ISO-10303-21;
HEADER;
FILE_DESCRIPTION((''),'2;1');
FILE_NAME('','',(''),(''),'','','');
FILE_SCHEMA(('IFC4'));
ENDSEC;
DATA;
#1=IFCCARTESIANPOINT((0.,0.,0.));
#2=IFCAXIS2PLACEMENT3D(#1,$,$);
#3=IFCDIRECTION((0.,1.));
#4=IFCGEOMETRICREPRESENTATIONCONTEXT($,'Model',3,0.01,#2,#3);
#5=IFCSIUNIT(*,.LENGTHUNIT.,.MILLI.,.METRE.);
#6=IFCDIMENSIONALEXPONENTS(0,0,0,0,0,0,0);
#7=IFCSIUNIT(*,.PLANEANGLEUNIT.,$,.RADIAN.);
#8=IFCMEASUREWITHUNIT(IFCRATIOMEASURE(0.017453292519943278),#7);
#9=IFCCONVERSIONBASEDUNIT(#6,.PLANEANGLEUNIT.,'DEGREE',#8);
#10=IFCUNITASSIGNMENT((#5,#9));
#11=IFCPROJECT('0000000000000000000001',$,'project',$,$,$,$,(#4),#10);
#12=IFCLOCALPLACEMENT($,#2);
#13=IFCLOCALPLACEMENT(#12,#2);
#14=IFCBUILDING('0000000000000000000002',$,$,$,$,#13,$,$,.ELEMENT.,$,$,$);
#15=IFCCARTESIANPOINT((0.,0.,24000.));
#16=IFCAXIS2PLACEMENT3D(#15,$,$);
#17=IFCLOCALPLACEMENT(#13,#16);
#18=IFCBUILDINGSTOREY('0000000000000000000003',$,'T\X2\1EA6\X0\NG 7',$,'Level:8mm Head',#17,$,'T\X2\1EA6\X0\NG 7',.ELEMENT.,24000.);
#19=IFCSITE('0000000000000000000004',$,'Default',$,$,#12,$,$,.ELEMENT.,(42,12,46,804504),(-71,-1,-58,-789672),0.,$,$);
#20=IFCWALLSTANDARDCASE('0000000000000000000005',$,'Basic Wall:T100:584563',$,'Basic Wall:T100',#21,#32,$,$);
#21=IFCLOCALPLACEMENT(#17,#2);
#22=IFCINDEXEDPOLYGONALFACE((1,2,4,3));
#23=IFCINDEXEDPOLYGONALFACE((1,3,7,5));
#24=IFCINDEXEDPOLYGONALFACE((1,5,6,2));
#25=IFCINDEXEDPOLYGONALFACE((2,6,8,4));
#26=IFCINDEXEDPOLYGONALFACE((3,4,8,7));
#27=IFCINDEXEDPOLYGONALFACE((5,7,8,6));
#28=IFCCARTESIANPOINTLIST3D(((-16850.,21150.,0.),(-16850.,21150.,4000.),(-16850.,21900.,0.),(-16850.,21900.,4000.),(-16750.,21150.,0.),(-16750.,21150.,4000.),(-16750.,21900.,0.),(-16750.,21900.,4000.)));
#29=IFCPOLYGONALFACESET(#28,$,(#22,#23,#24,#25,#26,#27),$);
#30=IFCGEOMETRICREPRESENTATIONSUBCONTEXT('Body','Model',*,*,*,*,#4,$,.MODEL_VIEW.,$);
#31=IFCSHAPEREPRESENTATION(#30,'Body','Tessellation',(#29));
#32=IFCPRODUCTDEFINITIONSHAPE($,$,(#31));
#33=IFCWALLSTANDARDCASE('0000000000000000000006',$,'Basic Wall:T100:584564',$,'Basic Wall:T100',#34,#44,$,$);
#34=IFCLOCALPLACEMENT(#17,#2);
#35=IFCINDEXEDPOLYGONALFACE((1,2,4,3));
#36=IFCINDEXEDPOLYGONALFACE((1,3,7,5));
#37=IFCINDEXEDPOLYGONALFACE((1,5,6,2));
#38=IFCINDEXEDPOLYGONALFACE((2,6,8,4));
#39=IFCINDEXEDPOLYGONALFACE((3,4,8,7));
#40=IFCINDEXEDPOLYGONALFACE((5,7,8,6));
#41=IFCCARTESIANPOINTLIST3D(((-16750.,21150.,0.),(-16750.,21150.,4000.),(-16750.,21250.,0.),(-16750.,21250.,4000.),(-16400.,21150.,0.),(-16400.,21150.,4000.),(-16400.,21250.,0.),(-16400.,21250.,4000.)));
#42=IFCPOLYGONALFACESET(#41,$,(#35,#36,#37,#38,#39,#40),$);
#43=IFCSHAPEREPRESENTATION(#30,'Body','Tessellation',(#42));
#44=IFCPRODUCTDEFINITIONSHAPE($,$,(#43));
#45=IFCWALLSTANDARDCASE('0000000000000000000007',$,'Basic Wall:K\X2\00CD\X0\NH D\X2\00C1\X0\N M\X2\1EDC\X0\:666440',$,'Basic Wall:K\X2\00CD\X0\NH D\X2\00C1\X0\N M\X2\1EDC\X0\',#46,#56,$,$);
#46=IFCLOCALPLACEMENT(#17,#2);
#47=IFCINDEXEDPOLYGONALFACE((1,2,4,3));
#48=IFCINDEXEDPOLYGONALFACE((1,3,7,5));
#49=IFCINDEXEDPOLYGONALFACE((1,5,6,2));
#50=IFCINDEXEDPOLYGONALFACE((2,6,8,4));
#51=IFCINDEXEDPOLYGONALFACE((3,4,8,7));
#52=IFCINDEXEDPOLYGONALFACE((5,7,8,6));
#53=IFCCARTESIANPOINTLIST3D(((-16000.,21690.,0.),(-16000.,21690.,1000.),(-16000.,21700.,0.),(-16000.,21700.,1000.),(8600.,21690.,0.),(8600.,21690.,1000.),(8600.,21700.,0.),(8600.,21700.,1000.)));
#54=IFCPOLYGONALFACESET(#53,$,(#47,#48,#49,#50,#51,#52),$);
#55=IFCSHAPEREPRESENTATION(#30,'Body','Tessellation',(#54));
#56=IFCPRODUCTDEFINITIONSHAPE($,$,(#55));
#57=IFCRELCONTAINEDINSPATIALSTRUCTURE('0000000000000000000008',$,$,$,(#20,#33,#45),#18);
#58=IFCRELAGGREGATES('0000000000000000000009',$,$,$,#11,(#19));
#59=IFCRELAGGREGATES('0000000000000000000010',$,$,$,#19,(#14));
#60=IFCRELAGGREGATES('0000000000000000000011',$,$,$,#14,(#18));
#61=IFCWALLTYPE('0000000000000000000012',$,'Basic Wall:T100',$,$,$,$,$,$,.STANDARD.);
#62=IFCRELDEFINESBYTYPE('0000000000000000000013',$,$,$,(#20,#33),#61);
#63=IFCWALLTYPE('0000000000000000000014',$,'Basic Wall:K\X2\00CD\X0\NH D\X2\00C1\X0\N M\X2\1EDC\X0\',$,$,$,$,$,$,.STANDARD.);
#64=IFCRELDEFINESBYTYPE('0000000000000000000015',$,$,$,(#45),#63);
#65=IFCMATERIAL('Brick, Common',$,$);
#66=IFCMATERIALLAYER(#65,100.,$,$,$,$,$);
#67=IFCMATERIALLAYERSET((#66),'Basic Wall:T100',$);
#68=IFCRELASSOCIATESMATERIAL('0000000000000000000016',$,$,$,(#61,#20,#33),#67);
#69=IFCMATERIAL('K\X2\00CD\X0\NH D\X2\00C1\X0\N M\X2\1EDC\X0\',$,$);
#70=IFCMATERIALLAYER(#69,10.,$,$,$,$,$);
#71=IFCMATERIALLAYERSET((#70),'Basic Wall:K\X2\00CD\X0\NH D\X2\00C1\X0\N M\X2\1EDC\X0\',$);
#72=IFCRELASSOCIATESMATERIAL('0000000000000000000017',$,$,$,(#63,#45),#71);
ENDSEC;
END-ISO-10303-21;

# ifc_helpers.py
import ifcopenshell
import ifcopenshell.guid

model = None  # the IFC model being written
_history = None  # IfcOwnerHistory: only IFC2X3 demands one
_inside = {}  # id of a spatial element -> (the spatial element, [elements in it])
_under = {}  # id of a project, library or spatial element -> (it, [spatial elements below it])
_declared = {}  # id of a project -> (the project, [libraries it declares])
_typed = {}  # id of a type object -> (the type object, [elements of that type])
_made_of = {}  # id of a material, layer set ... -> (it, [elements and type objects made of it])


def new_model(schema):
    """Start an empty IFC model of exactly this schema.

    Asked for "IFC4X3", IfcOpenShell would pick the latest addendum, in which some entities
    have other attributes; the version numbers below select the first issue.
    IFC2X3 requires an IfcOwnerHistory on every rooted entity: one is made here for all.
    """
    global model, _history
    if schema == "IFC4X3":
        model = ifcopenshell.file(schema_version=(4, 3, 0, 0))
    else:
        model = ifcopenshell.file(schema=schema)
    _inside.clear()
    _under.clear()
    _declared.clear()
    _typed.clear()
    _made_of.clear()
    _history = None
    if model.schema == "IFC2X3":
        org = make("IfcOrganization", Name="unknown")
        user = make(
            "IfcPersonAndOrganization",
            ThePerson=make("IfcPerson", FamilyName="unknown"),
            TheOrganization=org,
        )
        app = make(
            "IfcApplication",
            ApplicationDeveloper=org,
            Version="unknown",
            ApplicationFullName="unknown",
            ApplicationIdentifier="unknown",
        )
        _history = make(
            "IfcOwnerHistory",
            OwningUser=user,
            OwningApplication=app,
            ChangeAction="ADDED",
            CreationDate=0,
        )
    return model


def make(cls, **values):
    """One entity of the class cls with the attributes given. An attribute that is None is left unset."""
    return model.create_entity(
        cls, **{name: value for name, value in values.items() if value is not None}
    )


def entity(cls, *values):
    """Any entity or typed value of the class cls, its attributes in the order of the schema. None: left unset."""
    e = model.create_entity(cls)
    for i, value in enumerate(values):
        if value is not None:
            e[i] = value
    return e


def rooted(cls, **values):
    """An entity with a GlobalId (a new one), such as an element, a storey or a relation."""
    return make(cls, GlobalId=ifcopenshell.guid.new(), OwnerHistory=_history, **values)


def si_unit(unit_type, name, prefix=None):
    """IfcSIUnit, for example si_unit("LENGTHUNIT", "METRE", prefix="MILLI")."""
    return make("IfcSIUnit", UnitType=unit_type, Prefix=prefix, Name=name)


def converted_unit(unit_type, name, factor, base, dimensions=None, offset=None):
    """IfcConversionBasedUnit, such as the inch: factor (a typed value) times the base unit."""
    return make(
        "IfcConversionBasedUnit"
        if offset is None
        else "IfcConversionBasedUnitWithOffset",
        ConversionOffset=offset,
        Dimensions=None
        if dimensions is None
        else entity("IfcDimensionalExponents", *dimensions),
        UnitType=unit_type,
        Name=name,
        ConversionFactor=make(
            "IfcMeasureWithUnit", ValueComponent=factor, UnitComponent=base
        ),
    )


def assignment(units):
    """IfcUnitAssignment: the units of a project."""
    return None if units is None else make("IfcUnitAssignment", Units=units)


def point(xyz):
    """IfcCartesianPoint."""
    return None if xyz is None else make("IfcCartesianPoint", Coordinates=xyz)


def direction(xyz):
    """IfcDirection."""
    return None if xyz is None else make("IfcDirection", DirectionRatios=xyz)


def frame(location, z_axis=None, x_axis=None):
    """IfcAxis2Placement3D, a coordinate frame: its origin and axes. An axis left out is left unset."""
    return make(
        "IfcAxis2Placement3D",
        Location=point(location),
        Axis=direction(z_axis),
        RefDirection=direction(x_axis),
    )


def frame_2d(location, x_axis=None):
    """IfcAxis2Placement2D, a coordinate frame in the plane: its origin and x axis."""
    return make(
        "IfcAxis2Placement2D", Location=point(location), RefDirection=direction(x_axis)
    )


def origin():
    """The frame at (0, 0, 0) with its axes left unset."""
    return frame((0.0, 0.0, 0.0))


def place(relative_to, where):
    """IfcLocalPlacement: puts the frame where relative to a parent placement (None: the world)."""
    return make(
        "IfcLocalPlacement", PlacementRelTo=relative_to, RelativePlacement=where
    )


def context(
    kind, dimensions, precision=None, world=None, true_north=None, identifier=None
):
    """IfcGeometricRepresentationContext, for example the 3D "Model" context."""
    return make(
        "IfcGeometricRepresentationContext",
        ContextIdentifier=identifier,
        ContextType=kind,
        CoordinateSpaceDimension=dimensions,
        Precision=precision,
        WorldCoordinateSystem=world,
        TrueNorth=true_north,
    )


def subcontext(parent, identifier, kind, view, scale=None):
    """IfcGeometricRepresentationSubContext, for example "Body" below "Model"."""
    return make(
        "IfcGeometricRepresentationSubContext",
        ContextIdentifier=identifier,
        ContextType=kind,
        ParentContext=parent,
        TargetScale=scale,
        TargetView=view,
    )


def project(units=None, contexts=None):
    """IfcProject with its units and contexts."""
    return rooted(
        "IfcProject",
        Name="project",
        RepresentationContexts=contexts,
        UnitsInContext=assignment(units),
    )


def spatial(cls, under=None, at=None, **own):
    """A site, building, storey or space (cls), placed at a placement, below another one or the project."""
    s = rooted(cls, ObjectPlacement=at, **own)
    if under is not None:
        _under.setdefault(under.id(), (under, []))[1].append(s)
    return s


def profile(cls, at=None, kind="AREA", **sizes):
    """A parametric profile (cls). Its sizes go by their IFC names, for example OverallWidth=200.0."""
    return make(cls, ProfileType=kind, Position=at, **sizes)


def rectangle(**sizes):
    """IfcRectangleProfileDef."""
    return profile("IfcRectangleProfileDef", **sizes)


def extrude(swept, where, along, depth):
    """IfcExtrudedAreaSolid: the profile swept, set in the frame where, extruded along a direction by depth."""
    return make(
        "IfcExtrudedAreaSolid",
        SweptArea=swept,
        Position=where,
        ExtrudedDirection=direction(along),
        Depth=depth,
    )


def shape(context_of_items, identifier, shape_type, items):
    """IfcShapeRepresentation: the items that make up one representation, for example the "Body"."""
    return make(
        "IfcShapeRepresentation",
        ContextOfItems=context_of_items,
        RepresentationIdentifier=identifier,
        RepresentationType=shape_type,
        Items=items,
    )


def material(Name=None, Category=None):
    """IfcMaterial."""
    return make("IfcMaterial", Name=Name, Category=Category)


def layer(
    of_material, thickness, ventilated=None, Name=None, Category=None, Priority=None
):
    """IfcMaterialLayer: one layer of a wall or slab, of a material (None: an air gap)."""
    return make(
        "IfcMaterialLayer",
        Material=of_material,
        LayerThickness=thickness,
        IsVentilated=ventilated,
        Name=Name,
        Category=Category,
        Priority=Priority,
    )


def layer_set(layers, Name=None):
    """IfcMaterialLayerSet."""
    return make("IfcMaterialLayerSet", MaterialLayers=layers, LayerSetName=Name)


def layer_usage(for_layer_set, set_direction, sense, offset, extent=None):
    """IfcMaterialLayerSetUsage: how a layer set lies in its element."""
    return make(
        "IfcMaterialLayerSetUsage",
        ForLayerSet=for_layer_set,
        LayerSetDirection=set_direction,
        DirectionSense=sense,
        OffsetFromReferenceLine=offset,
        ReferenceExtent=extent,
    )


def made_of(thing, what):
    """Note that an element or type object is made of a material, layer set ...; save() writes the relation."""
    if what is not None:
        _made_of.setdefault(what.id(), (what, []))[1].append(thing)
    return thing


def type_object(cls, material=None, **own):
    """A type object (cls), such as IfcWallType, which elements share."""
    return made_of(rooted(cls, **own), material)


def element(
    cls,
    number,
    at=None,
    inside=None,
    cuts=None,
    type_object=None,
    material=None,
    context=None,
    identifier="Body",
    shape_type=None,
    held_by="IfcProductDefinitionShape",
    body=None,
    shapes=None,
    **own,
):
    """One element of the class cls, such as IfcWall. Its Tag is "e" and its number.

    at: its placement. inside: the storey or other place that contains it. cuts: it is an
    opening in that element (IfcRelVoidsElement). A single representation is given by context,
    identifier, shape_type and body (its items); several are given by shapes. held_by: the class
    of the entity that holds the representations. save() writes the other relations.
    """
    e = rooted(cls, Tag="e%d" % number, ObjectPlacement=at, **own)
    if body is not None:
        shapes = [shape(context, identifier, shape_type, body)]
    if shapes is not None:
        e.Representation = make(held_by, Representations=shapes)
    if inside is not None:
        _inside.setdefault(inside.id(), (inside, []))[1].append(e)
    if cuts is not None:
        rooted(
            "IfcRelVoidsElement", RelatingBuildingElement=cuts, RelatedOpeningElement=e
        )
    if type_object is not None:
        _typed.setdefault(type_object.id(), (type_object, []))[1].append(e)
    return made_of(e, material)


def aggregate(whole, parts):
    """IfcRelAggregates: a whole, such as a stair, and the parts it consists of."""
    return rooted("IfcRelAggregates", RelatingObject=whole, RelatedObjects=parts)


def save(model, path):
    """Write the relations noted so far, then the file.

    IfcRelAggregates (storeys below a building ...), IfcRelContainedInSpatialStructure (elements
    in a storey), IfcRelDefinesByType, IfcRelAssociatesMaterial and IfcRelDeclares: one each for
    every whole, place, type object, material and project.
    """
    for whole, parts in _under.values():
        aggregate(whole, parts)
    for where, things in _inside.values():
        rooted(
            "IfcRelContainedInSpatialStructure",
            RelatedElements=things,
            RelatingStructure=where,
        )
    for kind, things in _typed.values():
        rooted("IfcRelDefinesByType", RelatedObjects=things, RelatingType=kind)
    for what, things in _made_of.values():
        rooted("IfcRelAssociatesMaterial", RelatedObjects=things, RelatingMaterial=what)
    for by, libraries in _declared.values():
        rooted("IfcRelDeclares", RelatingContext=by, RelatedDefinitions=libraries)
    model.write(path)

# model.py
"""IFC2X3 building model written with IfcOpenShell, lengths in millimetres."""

from ifc_helpers import new_model, entity, si_unit, converted_unit, direction, frame, frame_2d, origin, place, context, subcontext, project, spatial, rectangle, extrude, material, layer, layer_set, layer_usage, type_object, element, save


model = new_model("IFC2X3")

# Units and contexts
model_context = context("Model", 3, precision=0.01, world=origin(), true_north=direction((0.0, 1.0)))
body_context = subcontext(model_context, "Body", "Model", "MODEL_VIEW")
ifc_project = project(units=[si_unit("LENGTHUNIT", "METRE", prefix="MILLI"), converted_unit("PLANEANGLEUNIT", "DEGREE", entity("IfcRatioMeasure", 0.017453292519943278), si_unit("PLANEANGLEUNIT", "RADIAN"), dimensions=[0, 0, 0, 0, 0, 0, 0])], contexts=[model_context])

# Site, building, storey
site_placement = place(None, origin())
site = spatial("IfcSite", under=ifc_project, at=site_placement, Name="Default", CompositionType="ELEMENT", RefLatitude=(42, 12, 46, 804504), RefLongitude=(-71, -1, -58, -789672), RefElevation=0.0)
building_placement = place(site_placement, origin())
building = spatial("IfcBuilding", under=site, at=building_placement, CompositionType="ELEMENT")
storey_placement = place(building_placement, frame((0.0, 0.0, 24000.0)))
storey = spatial("IfcBuildingStorey", under=building, at=storey_placement, Name="TẦNG 7", ObjectType="Level:8mm Head", LongName="TẦNG 7", CompositionType="ELEMENT", Elevation=24000.0)

# Walls
ifc_material_1 = material(Name="Brick, Common")
ifc_layer_1 = layer(ifc_material_1, 100.0)
ifc_layer_set_1 = layer_set([ifc_layer_1], Name="Basic Wall:T100")
ifc_layer_usage_1 = layer_usage(ifc_layer_set_1, "AXIS2", "POSITIVE", -50.0)
wall_type_1 = type_object("IfcWallType", Name="Basic Wall:T100", PredefinedType="STANDARD", material=ifc_layer_set_1)
wall_1_placement = place(storey_placement, frame((-16800.0, 21900.0, 0.0), z_axis=(0.0, 0.0, 1.0), x_axis=(0.0, -1.0, 0.0)))
element("IfcWallStandardCase", 1, at=wall_1_placement, inside=storey, type_object=wall_type_1, material=ifc_layer_usage_1, Name="Basic Wall:T100:584563", ObjectType="Basic Wall:T100", context=body_context, shape_type="SweptSolid", body=[
    extrude(rectangle(XDim=750.0, YDim=100.0, at=frame_2d((375.0, 0.0), x_axis=(-1.0, 0.0))), origin(), (0.0, 0.0, 1.0), 4000.0),
])
wall_2_placement = place(storey_placement, frame((-16750.0, 21200.0, 0.0)))
element("IfcWallStandardCase", 2, at=wall_2_placement, inside=storey, type_object=wall_type_1, material=ifc_layer_usage_1, Name="Basic Wall:T100:584564", ObjectType="Basic Wall:T100", context=body_context, shape_type="SweptSolid", body=[
    extrude(rectangle(XDim=350.0, YDim=100.0, at=frame_2d((175.0, 0.0), x_axis=(-1.0, 0.0))), origin(), (0.0, 0.0, 1.0), 4000.0),
])

# Wall
ifc_material_2 = material(Name="KÍNH DÁN MỜ")
ifc_layer_2 = layer(ifc_material_2, 10.0)
ifc_layer_set_2 = layer_set([ifc_layer_2], Name="Basic Wall:KÍNH DÁN MỜ")
ifc_layer_usage_2 = layer_usage(ifc_layer_set_2, "AXIS2", "NEGATIVE", 5.0)
wall_type_2 = type_object("IfcWallType", Name="Basic Wall:KÍNH DÁN MỜ", PredefinedType="STANDARD", material=ifc_layer_set_2)
wall_3_placement = place(storey_placement, frame((-16000.0, 21695.0, 0.0)))
element("IfcWallStandardCase", 3, at=wall_3_placement, inside=storey, type_object=wall_type_2, material=ifc_layer_usage_2, Name="Basic Wall:KÍNH DÁN MỜ:666440", ObjectType="Basic Wall:KÍNH DÁN MỜ", context=body_context, shape_type="SweptSolid", body=[
    extrude(rectangle(XDim=24600.0, YDim=10.0, at=frame_2d((12300.0, 0.0), x_axis=(-1.0, 0.0))), origin(), (0.0, 0.0, 1.0), 1000.0),
])

save(model, "model.ifc")
